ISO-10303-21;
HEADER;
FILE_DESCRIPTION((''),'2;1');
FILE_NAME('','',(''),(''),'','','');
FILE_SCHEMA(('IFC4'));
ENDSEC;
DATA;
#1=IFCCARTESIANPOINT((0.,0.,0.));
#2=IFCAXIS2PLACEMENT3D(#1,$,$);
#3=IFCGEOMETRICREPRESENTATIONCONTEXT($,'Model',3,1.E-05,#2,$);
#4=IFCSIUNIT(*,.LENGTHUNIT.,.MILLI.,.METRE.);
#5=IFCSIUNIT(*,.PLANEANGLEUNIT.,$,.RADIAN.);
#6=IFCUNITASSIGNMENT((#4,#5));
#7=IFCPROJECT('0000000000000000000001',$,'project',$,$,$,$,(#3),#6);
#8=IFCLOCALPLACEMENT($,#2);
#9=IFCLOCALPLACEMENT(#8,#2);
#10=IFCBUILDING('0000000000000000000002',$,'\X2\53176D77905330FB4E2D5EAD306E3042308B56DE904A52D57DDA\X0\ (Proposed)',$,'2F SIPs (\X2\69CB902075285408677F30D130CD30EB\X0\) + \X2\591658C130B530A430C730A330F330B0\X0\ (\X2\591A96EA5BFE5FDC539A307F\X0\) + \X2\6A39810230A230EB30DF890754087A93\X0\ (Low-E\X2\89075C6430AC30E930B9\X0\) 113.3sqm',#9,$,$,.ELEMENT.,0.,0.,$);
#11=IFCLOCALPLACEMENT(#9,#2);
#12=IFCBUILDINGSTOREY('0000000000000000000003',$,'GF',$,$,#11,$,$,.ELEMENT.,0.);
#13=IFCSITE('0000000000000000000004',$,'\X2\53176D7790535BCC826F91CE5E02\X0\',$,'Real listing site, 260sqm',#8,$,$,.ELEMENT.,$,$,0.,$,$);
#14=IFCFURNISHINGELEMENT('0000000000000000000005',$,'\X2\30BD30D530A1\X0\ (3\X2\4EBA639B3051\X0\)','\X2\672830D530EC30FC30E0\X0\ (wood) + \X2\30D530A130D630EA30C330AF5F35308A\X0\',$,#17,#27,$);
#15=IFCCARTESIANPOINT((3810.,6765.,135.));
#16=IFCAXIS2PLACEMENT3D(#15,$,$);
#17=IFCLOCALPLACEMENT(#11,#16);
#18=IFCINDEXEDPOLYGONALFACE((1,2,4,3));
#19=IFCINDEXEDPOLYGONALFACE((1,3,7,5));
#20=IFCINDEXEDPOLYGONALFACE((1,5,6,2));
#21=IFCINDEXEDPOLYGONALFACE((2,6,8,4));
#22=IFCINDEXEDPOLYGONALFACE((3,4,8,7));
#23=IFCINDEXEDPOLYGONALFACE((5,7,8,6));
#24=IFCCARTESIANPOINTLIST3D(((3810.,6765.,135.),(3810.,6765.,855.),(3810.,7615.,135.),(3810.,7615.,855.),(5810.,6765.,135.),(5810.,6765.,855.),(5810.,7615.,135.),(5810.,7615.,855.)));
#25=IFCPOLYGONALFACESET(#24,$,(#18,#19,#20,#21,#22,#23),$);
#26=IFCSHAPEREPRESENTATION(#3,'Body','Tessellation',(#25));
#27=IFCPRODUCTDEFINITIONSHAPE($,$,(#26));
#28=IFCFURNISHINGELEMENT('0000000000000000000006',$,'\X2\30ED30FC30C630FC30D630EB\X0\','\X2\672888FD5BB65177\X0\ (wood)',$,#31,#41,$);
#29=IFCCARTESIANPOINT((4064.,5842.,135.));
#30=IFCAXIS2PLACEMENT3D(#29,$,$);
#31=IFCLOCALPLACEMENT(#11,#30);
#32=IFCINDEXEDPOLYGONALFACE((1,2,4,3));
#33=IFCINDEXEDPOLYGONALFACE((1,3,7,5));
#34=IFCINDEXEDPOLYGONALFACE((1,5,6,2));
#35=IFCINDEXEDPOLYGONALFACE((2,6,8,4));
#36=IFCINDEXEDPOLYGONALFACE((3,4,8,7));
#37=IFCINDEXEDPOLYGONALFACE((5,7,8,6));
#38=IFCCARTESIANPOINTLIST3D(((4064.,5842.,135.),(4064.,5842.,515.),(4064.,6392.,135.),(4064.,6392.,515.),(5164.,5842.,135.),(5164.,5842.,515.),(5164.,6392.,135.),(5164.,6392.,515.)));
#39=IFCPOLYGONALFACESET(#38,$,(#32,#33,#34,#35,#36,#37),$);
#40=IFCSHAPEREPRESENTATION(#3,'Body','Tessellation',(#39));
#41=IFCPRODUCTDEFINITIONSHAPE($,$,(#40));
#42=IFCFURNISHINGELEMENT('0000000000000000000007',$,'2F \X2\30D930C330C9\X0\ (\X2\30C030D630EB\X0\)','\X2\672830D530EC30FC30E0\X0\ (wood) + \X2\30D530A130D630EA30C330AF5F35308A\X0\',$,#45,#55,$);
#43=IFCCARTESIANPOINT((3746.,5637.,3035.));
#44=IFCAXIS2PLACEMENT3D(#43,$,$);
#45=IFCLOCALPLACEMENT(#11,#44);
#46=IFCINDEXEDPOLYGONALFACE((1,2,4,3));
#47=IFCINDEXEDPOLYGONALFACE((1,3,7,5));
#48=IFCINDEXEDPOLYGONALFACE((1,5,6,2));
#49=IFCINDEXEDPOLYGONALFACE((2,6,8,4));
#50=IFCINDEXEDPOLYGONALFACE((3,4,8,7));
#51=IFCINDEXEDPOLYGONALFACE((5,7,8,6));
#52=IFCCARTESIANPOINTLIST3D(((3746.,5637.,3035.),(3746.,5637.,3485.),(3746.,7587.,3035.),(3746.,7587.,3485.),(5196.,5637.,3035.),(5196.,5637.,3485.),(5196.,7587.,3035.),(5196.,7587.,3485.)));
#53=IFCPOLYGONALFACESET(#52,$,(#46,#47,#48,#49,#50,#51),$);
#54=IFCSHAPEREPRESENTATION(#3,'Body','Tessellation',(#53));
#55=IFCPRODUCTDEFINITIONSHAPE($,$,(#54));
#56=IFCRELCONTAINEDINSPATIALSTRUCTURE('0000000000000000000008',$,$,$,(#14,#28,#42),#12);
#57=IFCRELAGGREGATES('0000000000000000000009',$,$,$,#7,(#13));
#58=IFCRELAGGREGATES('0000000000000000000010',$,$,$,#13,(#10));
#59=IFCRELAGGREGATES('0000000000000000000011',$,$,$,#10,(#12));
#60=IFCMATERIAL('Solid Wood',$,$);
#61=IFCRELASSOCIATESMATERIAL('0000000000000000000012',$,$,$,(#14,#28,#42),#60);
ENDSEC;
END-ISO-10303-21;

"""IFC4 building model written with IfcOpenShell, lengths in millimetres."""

from ifc_helpers import new_model, si_unit, frame, frame_2d, origin, place, context, project, spatial, rectangle, extrude, material, element, save


model = new_model("IFC4")

# Units and contexts
model_context = context("Model", 3, precision=1e-05, world=origin())
ifc_project = project(units=[si_unit("LENGTHUNIT", "METRE", prefix="MILLI"), si_unit("PLANEANGLEUNIT", "RADIAN")], contexts=[model_context])

# Site, building, storey
site_placement = place(None, origin())
site = spatial("IfcSite", under=ifc_project, at=site_placement, Name="北海道富良野市", ObjectType="Real listing site, 260sqm", CompositionType="ELEMENT", RefElevation=0.0)
building_placement = place(site_placement, origin())
building = spatial("IfcBuilding", under=site, at=building_placement, Name="北海道・中庭のある回遊動線 (Proposed)", ObjectType="2F SIPs (構造用合板パネル) + 外壁サイディング (多雪対応厚み) + 樹脂アルミ複合窓 (Low-E複層ガラス) 113.3sqm", CompositionType="ELEMENT", ElevationOfRefHeight=0.0, ElevationOfTerrain=0.0)
storey_placement = place(building_placement, origin())
storey = spatial("IfcBuildingStorey", under=building, at=storey_placement, Name="GF", CompositionType="ELEMENT", Elevation=0.0)

# Shared definitions
ifc_material_1 = material(Name="Solid Wood")

# Furnishing elements
furnishing_1_placement = place(storey_placement, frame((3810.0, 6765.0, 135.0)))
element("IfcFurnishingElement", 1, at=furnishing_1_placement, inside=storey, material=ifc_material_1, Name="ソファ (3人掛け)", Description="木フレーム (wood) + ファブリック張り", context=model_context, shape_type="SweptSolid", body=[
    extrude(rectangle(XDim=2000.0, YDim=850.0, at=frame_2d((1000.0, 425.0))), frame((3810.0, 6765.0, 135.0)), (0.0, 0.0, 1.0), 720.0),
])
furnishing_2_placement = place(storey_placement, frame((4064.0, 5842.0, 135.0)))
element("IfcFurnishingElement", 2, at=furnishing_2_placement, inside=storey, material=ifc_material_1, Name="ローテーブル", Description="木製家具 (wood)", context=model_context, shape_type="SweptSolid", body=[
    extrude(rectangle(XDim=1100.0, YDim=550.0, at=frame_2d((550.0, 275.0))), frame((4064.0, 5842.0, 135.0)), (0.0, 0.0, 1.0), 380.0),
])
furnishing_3_placement = place(storey_placement, frame((3746.0, 5637.0, 3035.0)))
element("IfcFurnishingElement", 3, at=furnishing_3_placement, inside=storey, material=ifc_material_1, Name="2F ベッド (ダブル)", Description="木フレーム (wood) + ファブリック張り", context=model_context, shape_type="SweptSolid", body=[
    extrude(rectangle(XDim=1450.0, YDim=1950.0, at=frame_2d((725.0, 975.0))), frame((3746.0, 5637.0, 3035.0)), (0.0, 0.0, 1.0), 450.0),
])

save(model, "model.ifc")
